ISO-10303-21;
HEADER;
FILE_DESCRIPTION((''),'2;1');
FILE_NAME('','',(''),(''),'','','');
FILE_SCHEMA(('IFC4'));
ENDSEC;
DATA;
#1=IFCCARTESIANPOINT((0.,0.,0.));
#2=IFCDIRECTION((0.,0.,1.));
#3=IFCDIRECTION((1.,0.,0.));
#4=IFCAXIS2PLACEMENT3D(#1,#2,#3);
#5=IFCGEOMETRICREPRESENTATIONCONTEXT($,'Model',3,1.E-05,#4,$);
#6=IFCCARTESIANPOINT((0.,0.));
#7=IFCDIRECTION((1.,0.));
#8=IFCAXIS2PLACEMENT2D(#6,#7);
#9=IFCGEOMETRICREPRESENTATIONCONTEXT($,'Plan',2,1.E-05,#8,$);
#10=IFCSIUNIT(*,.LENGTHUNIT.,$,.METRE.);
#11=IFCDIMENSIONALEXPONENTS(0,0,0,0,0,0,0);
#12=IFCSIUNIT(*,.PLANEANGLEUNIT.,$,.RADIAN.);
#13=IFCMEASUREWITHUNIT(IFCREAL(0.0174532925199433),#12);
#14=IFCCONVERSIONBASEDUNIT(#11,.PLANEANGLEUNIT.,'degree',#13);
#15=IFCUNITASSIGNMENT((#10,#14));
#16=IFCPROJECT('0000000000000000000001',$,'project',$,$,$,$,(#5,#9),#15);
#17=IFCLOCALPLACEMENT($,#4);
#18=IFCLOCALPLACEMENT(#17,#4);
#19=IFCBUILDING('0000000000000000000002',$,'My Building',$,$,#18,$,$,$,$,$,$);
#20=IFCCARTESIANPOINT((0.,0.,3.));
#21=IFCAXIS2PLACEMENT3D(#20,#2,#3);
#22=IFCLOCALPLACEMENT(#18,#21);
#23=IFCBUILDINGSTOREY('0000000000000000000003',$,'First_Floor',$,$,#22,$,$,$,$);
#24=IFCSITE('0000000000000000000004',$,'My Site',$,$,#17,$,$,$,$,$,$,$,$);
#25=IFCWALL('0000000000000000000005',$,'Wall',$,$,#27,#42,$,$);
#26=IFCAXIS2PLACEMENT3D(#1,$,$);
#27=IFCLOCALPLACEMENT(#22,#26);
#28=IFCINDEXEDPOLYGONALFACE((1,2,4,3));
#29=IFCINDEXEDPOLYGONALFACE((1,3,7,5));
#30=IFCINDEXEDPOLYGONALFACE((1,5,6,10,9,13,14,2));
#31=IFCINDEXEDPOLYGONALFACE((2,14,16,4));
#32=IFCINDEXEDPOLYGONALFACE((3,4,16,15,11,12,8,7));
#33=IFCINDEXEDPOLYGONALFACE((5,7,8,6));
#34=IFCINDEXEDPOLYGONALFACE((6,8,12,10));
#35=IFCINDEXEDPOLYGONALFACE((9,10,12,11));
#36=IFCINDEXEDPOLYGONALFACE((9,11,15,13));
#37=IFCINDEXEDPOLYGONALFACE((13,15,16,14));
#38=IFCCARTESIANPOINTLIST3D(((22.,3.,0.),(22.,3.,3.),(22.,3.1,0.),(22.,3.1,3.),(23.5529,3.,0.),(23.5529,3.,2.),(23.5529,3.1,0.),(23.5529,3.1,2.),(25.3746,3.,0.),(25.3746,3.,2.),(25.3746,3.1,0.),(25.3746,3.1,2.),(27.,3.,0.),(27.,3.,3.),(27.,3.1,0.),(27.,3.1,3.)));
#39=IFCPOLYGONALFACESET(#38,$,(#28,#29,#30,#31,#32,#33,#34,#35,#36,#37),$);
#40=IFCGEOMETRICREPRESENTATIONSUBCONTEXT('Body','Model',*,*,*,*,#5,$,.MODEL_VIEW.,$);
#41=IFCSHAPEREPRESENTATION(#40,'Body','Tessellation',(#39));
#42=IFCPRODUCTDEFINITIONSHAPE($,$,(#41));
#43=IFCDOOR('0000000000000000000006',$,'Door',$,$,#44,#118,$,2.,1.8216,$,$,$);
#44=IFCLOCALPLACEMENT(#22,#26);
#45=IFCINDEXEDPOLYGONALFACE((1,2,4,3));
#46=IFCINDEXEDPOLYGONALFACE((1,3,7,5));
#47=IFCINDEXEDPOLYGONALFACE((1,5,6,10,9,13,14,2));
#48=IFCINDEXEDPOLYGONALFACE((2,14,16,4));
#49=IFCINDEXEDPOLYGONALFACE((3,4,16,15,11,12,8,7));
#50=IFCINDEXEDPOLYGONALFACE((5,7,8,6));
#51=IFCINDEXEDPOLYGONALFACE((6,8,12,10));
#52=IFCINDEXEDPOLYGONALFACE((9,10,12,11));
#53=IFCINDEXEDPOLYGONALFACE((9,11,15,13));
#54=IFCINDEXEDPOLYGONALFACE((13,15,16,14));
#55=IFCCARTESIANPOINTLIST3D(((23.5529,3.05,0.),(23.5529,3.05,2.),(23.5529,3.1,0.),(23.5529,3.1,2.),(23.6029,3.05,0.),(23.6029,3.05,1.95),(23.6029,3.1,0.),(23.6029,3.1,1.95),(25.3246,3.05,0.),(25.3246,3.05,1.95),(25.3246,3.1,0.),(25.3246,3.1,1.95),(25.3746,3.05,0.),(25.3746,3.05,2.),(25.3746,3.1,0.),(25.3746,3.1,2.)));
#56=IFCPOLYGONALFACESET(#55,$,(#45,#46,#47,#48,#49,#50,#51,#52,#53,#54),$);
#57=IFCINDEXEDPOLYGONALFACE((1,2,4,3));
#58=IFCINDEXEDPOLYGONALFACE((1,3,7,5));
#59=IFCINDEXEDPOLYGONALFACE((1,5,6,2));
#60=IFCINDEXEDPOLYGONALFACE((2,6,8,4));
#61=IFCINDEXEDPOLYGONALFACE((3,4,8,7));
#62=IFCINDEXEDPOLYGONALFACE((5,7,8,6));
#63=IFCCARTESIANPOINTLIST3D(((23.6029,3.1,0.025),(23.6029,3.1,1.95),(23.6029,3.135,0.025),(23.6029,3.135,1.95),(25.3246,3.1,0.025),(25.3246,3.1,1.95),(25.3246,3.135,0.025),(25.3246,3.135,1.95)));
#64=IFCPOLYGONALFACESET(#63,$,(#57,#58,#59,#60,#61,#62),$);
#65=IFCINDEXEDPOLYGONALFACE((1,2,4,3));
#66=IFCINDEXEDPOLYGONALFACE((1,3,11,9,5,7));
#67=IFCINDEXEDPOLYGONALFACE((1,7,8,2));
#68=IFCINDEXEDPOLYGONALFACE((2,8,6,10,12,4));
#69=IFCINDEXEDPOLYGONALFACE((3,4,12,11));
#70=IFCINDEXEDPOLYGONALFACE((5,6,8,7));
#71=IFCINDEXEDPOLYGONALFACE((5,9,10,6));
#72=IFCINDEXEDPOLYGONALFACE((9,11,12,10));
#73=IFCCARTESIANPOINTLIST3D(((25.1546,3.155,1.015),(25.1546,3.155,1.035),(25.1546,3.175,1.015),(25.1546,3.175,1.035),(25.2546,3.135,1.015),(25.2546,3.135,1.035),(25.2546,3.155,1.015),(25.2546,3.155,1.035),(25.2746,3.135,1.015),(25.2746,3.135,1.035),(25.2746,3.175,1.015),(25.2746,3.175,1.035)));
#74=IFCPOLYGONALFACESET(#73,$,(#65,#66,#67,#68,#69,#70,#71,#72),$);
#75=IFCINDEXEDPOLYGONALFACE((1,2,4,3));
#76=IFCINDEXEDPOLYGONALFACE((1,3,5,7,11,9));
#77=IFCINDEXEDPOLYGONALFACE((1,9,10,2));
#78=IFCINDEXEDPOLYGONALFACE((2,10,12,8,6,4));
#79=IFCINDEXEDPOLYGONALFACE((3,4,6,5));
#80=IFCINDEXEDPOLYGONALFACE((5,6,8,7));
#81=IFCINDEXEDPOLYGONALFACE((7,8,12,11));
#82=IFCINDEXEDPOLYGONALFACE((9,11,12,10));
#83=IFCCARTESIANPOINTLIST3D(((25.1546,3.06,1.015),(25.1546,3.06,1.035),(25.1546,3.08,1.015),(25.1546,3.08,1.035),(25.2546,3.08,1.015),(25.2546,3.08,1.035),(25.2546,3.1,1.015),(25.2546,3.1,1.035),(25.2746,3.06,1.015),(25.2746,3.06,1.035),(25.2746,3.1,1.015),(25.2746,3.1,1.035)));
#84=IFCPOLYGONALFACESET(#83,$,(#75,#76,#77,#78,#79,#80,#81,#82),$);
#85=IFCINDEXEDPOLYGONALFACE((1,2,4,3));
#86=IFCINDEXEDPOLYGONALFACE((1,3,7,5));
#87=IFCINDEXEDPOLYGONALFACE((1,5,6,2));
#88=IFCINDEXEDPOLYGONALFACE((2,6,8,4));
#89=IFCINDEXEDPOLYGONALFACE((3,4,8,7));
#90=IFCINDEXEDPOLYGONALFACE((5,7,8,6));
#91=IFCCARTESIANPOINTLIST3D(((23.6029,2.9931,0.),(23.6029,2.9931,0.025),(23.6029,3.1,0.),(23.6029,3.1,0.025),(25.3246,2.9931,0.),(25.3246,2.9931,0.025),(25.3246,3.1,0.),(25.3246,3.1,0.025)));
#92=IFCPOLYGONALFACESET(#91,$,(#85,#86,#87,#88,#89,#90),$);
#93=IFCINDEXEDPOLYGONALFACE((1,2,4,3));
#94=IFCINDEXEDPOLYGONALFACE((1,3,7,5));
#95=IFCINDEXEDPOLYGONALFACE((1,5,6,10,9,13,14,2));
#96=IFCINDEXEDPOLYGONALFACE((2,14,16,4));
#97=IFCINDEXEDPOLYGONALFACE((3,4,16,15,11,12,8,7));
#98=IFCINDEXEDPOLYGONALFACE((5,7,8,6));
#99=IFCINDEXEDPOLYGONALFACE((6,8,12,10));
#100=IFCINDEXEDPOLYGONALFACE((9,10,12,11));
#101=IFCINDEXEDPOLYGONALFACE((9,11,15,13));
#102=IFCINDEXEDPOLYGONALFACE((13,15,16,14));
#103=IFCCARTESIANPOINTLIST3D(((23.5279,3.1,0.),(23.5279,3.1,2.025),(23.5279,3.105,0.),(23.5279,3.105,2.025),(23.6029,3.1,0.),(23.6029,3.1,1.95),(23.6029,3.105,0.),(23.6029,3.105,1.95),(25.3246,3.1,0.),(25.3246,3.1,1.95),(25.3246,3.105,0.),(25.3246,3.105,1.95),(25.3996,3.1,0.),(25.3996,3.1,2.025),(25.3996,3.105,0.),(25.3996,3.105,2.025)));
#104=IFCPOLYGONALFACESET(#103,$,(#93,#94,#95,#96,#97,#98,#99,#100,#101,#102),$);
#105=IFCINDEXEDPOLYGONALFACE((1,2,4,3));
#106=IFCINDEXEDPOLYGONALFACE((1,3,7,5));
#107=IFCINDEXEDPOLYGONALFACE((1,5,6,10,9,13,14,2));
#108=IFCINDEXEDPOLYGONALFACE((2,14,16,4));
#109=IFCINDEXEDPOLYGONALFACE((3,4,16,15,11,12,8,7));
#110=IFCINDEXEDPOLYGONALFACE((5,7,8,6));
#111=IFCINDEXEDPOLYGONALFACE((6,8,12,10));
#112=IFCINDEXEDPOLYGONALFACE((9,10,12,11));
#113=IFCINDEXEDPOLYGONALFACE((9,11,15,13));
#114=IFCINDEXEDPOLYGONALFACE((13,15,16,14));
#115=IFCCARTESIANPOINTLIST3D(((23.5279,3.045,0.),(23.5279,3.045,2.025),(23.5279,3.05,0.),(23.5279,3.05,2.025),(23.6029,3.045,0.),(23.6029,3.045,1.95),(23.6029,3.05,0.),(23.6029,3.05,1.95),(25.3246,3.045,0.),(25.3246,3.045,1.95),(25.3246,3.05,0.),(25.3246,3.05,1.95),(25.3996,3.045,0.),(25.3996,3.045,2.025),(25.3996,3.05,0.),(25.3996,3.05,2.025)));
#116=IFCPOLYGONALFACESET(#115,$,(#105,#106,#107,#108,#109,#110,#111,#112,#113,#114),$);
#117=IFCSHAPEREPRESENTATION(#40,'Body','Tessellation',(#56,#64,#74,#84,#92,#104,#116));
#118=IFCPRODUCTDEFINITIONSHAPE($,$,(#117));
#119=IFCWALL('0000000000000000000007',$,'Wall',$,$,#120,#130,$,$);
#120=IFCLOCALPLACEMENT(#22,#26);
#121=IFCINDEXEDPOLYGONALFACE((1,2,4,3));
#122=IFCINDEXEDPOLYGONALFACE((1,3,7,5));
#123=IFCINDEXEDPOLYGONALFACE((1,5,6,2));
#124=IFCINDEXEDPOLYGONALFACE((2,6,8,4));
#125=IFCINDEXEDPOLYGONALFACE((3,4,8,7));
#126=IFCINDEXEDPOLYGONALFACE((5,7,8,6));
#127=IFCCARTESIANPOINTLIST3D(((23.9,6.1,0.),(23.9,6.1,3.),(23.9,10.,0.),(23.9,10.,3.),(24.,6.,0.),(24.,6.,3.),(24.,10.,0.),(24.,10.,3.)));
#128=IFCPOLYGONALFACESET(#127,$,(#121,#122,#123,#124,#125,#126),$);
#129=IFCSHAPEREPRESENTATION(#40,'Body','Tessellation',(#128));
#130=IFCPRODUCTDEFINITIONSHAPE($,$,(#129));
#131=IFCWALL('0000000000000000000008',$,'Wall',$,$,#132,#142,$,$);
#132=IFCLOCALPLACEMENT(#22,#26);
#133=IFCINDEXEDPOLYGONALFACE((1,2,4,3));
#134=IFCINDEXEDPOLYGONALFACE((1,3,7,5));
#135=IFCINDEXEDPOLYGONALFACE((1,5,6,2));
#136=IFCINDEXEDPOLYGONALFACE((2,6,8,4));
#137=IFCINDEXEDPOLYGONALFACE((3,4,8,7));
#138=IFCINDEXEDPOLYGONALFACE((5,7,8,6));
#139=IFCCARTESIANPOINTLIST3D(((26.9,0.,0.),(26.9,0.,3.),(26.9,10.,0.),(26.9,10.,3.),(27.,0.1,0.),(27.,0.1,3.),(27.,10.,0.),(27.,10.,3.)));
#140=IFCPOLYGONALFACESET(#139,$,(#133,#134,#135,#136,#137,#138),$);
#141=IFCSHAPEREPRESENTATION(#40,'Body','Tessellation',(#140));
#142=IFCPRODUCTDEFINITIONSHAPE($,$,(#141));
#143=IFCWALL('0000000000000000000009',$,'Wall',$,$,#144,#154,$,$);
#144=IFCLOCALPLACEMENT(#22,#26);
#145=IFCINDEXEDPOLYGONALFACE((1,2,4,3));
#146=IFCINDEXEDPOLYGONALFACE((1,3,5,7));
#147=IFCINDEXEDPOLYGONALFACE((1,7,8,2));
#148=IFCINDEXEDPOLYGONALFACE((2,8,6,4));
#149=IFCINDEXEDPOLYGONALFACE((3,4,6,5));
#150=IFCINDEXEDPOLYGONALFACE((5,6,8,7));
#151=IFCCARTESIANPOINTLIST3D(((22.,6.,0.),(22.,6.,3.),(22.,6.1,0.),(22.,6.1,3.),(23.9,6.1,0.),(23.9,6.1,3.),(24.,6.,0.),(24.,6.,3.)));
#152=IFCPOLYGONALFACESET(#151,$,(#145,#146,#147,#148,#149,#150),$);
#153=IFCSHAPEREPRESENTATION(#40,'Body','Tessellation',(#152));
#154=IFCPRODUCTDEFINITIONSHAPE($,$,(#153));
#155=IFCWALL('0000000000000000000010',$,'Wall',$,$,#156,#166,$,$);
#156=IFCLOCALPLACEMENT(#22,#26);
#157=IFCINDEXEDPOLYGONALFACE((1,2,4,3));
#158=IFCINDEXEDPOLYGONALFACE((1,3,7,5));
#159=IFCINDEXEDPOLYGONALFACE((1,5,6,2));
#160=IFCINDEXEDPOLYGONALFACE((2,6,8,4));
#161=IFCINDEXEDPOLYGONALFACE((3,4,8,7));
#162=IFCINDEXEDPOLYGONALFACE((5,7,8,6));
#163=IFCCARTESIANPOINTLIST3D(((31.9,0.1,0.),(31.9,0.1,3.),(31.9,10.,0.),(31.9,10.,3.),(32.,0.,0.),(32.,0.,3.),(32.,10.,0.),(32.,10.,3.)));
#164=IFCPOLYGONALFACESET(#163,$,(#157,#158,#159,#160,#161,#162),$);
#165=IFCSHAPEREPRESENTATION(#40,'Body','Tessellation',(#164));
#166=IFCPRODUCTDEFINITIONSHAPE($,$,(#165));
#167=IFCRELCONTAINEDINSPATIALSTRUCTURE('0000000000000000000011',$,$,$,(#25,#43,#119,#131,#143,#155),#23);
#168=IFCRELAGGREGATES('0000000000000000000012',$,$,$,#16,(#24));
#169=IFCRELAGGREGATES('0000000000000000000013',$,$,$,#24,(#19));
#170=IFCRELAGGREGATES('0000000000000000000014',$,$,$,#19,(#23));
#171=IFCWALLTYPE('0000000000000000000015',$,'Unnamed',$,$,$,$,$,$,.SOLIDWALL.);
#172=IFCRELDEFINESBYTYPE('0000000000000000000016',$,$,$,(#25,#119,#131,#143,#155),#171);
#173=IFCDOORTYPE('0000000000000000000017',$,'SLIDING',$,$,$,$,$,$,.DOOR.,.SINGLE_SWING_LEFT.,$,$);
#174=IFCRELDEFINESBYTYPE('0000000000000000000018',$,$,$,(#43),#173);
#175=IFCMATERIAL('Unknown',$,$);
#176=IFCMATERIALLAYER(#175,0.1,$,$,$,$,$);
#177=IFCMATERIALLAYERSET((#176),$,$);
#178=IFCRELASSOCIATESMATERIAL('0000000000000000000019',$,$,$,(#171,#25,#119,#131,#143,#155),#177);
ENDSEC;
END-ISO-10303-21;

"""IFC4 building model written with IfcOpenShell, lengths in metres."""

from ifc_helpers import new_model, entity, si_unit, converted_unit, frame, origin_with_axes, origin_2d_with_axis, place, context, subcontext, project, spatial, line, indexed_curve, outline, extrude, shape, source, transform, mapped, material, layer, layer_set, layer_usage, type_object, type_shapes, element, fill, save


model = new_model("IFC4")

# Units and contexts
model_context = context("Model", 3, precision=1e-05, world=origin_with_axes())
plan_context = context("Plan", 2, precision=1e-05, world=origin_2d_with_axis())
body_context_1 = subcontext(model_context, "Body", "Model", "MODEL_VIEW")
body_context_2 = subcontext(plan_context, "Body", "Plan", "PLAN_VIEW")
ifc_project = project(units=[si_unit("LENGTHUNIT", "METRE"), converted_unit("PLANEANGLEUNIT", "degree", entity("IfcReal", 0.0174532925199433), si_unit("PLANEANGLEUNIT", "RADIAN"), dimensions=[0, 0, 0, 0, 0, 0, 0])], contexts=[model_context, plan_context])

# Site, building, storey
site_placement = place(None, origin_with_axes())
site = spatial("IfcSite", under=ifc_project, at=site_placement, Name="My Site")
building_placement = place(site_placement, origin_with_axes())
building = spatial("IfcBuilding", under=site, at=building_placement, Name="My Building")
storey_placement = place(building_placement, frame((0.0, 0.0, 3.0), z_axis=(0.0, 0.0, 1.0), x_axis=(1.0, 0.0, 0.0)))
storey = spatial("IfcBuildingStorey", under=building, at=storey_placement, Name="First_Floor")

# Wall, opening, door
ifc_material = material(Name="Unknown")
ifc_layer = layer(ifc_material, 0.1)
ifc_layer_set = layer_set([ifc_layer])
ifc_layer_usage_1 = layer_usage(ifc_layer_set, "AXIS2", "POSITIVE", 0.0)
wall_type = type_object("IfcWallType", Name="Unnamed", PredefinedType="SOLIDWALL", material=ifc_layer_set)
wall_1_placement = place(storey_placement, frame((22.0, 3.0, 0.0), z_axis=(0.0, 0.0, 1.0), x_axis=(1.0, 0.0, 0.0)))
wall_1 = element("IfcWall", 1, at=wall_1_placement, inside=storey, type_object=wall_type, material=ifc_layer_usage_1, Name="Wall", context=body_context_1, shape_type="SweptSolid", body=[
    extrude(outline(indexed_curve([(0.0, 0.0), (0.0, 0.1), (5.0, 0.1), (5.0, 0.0)], segments=[line(1, 2, 3, 4, 1)])), origin_with_axes(), (0.0, 0.0, 1.0), 3.0),
])
shared_shape_1 = source(origin_with_axes(), body_context_1, "Body", "SweptSolid", [
    extrude(outline(indexed_curve([(0.0, 0.0), (1.8216, 0.0), (1.8216, 2.0), (0.0, 2.0)], segments=[line(1, 2, 3, 4, 1)])), frame((0.0, -0.6, 0.0), z_axis=(0.0, -1.0, 0.0), x_axis=(1.0, 0.0, 0.0)), (0.0, 0.0, -1.0), 1.2),
])
opening_1_placement = place(wall_1_placement, frame((3.3746, 0.1, 0.0), z_axis=(0.0, 0.0, 1.0), x_axis=(-1.0, 0.0, 0.0)))
opening_1 = element("IfcOpeningElement", 2, at=opening_1_placement, cuts=wall_1, PredefinedType="OPENING", context=body_context_1, shape_type="MappedRepresentation", body=[
    mapped(shared_shape_1, transform((0.0, 0.0, 0.0), x_axis=(1.0, 0.0, 0.0), y_axis=(0.0, 1.0, 0.0), z_axis=(0.0, 0.0, 1.0), scale=1.0)),
])
door_type = type_object("IfcDoorType", Name="SLIDING", OperationType="SINGLE_SWING_LEFT", PredefinedType="DOOR")
shared_shape_2 = source(origin_with_axes(), body_context_1, "Body", "SweptSolid", [
    extrude(outline(indexed_curve([(0.0, 0.0), (0.0, 2.0), (1.8216, 2.0), (1.8216, 0.0), (1.7716, 0.0), (1.7716, 1.95), (0.05, 1.95), (0.05, 0.0)], segments=[line(1, 2, 3, 4, 5, 6, 7, 8, 1)])), frame((0.0, 0.0, 0.0), z_axis=(0.0, -1.0, 0.0), x_axis=(1.0, 0.0, 0.0)), (0.0, 0.0, -1.0), 0.05),
    extrude(outline(indexed_curve([(0.0, 0.0), (1.7216, 0.0), (1.7216, 0.035), (0.0, 0.035)], segments=[line(1, 2, 3, 4, 1)])), frame((0.05, -0.035, 0.025), z_axis=(0.0, 0.0, 1.0), x_axis=(1.0, 0.0, 0.0)), (0.0, 0.0, 1.0), 1.925),
    extrude(outline(indexed_curve([(0.0, 0.0), (0.0, -0.04), (0.12, -0.04), (0.12, -0.02), (0.02, -0.02), (0.02, 0.0)], segments=[line(1, 2, 3, 4, 5, 6, 1)])), frame((0.1, -0.035, 1.015), z_axis=(0.0, 0.0, 1.0), x_axis=(1.0, 0.0, 0.0)), (0.0, 0.0, 1.0), 0.02),
    extrude(outline(indexed_curve([(0.0, 0.0), (0.0, 0.04), (0.12, 0.04), (0.12, 0.02), (0.02, 0.02), (0.02, 0.0)], segments=[line(1, 2, 3, 4, 5, 6, 1)])), frame((0.1, 0.0, 1.015), z_axis=(0.0, 0.0, 1.0), x_axis=(1.0, 0.0, 0.0)), (0.0, 0.0, 1.0), 0.02),
    extrude(outline(indexed_curve([(0.0, 0.0), (1.7216, 0.0), (1.7216, 0.1069), (0.0, 0.1069)], segments=[line(1, 2, 3, 4, 1)])), frame((0.05, 0.0, 0.0), z_axis=(0.0, 0.0, 1.0), x_axis=(1.0, 0.0, 0.0)), (0.0, 0.0, 1.0), 0.025),
    extrude(outline(indexed_curve([(0.0, 0.0), (0.0, 2.025), (1.8716, 2.025), (1.8716, 0.0), (1.7966, 0.0), (1.7966, 1.95), (0.075, 1.95), (0.075, 0.0)], segments=[line(1, 2, 3, 4, 5, 6, 7, 8, 1)])), frame((-0.025, -0.005, 0.0), z_axis=(0.0, -1.0, 0.0), x_axis=(1.0, 0.0, 0.0)), (0.0, 0.0, -1.0), 0.005),
    extrude(outline(indexed_curve([(0.0, 0.0), (0.0, 2.025), (1.8716, 2.025), (1.8716, 0.0), (1.7966, 0.0), (1.7966, 1.95), (0.075, 1.95), (0.075, 0.0)], segments=[line(1, 2, 3, 4, 5, 6, 7, 8, 1)])), frame((-0.025, 0.05, 0.0), z_axis=(0.0, -1.0, 0.0), x_axis=(1.0, 0.0, 0.0)), (0.0, 0.0, -1.0), 0.005),
])
shared_shape_3 = source(origin_with_axes(), body_context_2, "Body", "Curve2D", [
    entity("IfcIndexedPolyCurve", entity("IfcCartesianPointList2D", [[0.0, 0.0], [0.05, 0.0], [0.05, 0.05], [0.0, 0.05]]), [entity("IfcLineIndex", [1, 2, 3, 4, 1])]),
    entity("IfcIndexedPolyCurve", entity("IfcCartesianPointList2D", [[1.8216, 0.0], [1.7716, 0.0], [1.7716, 0.05], [1.8216, 0.05]]), [entity("IfcLineIndex", [1, 2, 3, 4, 1])]),
    entity("IfcIndexedPolyCurve", entity("IfcCartesianPointList2D", [[2.6325, -0.035], [0.9108, -0.035], [0.9108, 0.0], [2.6325, 0.0]]), [entity("IfcLineIndex", [1, 2, 3, 4, 1])]),
])
type_shapes(door_type, [shared_shape_2, shared_shape_3])
door_1_placement = place(opening_1_placement, origin_with_axes())
door_1 = element("IfcDoor", 3, at=door_1_placement, inside=storey, type_object=door_type, Name="Door", OverallHeight=2.0, OverallWidth=1.8216, shapes=[
    shape(body_context_1, "Body", "MappedRepresentation", [mapped(shared_shape_2, transform((0.0, 0.0, 0.0), x_axis=(1.0, 0.0, 0.0), y_axis=(0.0, 1.0, 0.0), z_axis=(0.0, 0.0, 1.0), scale=1.0))]),
    shape(body_context_2, "Body", "MappedRepresentation", [mapped(shared_shape_3, transform((0.0, 0.0, 0.0), x_axis=(1.0, 0.0, 0.0), y_axis=(0.0, 1.0, 0.0), z_axis=(0.0, 0.0, 1.0), scale=1.0))]),
])
fill(opening_1, door_1)

# Walls
ifc_layer_usage_2 = layer_usage(ifc_layer_set, "AXIS2", "POSITIVE", 0.0)
wall_2_placement = place(storey_placement, frame((24.0, 6.0, 0.0), z_axis=(0.0, 0.0, 1.0), x_axis=(0.0, 1.0, 0.0)))
element("IfcWall", 4, at=wall_2_placement, inside=storey, type_object=wall_type, material=ifc_layer_usage_2, Name="Wall", context=body_context_1, shape_type="SweptSolid", body=[
    extrude(outline(indexed_curve([(0.0, 0.0), (0.1, 0.1), (4.0, 0.1), (4.0, 0.0)], segments=[line(1, 2, 3, 4, 1)])), origin_with_axes(), (0.0, 0.0, 1.0), 3.0),
])
ifc_layer_usage_3 = layer_usage(ifc_layer_set, "AXIS2", "POSITIVE", 0.0)
wall_3_placement = place(storey_placement, frame((26.9, 10.0, 0.0), z_axis=(0.0, 0.0, 1.0), x_axis=(0.0, -1.0, 0.0)))
element("IfcWall", 5, at=wall_3_placement, inside=storey, type_object=wall_type, material=ifc_layer_usage_3, Name="Wall", context=body_context_1, shape_type="SweptSolid", body=[
    extrude(outline(indexed_curve([(0.0, 0.0), (0.0, 0.1), (9.9, 0.1), (10.0, 0.0)], segments=[line(1, 2, 3, 4, 1)])), origin_with_axes(), (0.0, 0.0, 1.0), 3.0),
])
ifc_layer_usage_4 = layer_usage(ifc_layer_set, "AXIS2", "POSITIVE", 0.0)
wall_4_placement = place(storey_placement, frame((22.0, 6.0, 0.0), z_axis=(0.0, 0.0, 1.0), x_axis=(1.0, 0.0, 0.0)))
element("IfcWall", 6, at=wall_4_placement, inside=storey, type_object=wall_type, material=ifc_layer_usage_4, Name="Wall", context=body_context_1, shape_type="SweptSolid", body=[
    extrude(outline(indexed_curve([(0.0, 0.0), (0.0, 0.1), (1.9, 0.1), (2.0, 0.0)], segments=[line(1, 2, 3, 4, 1)])), origin_with_axes(), (0.0, 0.0, 1.0), 3.0),
])
ifc_layer_usage_5 = layer_usage(ifc_layer_set, "AXIS2", "POSITIVE", 0.0)
wall_5_placement = place(storey_placement, frame((31.9, 10.0, 0.0), z_axis=(0.0, 0.0, 1.0), x_axis=(0.0, -1.0, 0.0)))
element("IfcWall", 7, at=wall_5_placement, inside=storey, type_object=wall_type, material=ifc_layer_usage_5, Name="Wall", context=body_context_1, shape_type="SweptSolid", body=[
    extrude(outline(indexed_curve([(0.0, 0.0), (0.0, 0.1), (10.0, 0.1), (9.9, 0.0)], segments=[line(1, 2, 3, 4, 1)])), origin_with_axes(), (0.0, 0.0, 1.0), 3.0),
])

save(model, "model.ifc")
